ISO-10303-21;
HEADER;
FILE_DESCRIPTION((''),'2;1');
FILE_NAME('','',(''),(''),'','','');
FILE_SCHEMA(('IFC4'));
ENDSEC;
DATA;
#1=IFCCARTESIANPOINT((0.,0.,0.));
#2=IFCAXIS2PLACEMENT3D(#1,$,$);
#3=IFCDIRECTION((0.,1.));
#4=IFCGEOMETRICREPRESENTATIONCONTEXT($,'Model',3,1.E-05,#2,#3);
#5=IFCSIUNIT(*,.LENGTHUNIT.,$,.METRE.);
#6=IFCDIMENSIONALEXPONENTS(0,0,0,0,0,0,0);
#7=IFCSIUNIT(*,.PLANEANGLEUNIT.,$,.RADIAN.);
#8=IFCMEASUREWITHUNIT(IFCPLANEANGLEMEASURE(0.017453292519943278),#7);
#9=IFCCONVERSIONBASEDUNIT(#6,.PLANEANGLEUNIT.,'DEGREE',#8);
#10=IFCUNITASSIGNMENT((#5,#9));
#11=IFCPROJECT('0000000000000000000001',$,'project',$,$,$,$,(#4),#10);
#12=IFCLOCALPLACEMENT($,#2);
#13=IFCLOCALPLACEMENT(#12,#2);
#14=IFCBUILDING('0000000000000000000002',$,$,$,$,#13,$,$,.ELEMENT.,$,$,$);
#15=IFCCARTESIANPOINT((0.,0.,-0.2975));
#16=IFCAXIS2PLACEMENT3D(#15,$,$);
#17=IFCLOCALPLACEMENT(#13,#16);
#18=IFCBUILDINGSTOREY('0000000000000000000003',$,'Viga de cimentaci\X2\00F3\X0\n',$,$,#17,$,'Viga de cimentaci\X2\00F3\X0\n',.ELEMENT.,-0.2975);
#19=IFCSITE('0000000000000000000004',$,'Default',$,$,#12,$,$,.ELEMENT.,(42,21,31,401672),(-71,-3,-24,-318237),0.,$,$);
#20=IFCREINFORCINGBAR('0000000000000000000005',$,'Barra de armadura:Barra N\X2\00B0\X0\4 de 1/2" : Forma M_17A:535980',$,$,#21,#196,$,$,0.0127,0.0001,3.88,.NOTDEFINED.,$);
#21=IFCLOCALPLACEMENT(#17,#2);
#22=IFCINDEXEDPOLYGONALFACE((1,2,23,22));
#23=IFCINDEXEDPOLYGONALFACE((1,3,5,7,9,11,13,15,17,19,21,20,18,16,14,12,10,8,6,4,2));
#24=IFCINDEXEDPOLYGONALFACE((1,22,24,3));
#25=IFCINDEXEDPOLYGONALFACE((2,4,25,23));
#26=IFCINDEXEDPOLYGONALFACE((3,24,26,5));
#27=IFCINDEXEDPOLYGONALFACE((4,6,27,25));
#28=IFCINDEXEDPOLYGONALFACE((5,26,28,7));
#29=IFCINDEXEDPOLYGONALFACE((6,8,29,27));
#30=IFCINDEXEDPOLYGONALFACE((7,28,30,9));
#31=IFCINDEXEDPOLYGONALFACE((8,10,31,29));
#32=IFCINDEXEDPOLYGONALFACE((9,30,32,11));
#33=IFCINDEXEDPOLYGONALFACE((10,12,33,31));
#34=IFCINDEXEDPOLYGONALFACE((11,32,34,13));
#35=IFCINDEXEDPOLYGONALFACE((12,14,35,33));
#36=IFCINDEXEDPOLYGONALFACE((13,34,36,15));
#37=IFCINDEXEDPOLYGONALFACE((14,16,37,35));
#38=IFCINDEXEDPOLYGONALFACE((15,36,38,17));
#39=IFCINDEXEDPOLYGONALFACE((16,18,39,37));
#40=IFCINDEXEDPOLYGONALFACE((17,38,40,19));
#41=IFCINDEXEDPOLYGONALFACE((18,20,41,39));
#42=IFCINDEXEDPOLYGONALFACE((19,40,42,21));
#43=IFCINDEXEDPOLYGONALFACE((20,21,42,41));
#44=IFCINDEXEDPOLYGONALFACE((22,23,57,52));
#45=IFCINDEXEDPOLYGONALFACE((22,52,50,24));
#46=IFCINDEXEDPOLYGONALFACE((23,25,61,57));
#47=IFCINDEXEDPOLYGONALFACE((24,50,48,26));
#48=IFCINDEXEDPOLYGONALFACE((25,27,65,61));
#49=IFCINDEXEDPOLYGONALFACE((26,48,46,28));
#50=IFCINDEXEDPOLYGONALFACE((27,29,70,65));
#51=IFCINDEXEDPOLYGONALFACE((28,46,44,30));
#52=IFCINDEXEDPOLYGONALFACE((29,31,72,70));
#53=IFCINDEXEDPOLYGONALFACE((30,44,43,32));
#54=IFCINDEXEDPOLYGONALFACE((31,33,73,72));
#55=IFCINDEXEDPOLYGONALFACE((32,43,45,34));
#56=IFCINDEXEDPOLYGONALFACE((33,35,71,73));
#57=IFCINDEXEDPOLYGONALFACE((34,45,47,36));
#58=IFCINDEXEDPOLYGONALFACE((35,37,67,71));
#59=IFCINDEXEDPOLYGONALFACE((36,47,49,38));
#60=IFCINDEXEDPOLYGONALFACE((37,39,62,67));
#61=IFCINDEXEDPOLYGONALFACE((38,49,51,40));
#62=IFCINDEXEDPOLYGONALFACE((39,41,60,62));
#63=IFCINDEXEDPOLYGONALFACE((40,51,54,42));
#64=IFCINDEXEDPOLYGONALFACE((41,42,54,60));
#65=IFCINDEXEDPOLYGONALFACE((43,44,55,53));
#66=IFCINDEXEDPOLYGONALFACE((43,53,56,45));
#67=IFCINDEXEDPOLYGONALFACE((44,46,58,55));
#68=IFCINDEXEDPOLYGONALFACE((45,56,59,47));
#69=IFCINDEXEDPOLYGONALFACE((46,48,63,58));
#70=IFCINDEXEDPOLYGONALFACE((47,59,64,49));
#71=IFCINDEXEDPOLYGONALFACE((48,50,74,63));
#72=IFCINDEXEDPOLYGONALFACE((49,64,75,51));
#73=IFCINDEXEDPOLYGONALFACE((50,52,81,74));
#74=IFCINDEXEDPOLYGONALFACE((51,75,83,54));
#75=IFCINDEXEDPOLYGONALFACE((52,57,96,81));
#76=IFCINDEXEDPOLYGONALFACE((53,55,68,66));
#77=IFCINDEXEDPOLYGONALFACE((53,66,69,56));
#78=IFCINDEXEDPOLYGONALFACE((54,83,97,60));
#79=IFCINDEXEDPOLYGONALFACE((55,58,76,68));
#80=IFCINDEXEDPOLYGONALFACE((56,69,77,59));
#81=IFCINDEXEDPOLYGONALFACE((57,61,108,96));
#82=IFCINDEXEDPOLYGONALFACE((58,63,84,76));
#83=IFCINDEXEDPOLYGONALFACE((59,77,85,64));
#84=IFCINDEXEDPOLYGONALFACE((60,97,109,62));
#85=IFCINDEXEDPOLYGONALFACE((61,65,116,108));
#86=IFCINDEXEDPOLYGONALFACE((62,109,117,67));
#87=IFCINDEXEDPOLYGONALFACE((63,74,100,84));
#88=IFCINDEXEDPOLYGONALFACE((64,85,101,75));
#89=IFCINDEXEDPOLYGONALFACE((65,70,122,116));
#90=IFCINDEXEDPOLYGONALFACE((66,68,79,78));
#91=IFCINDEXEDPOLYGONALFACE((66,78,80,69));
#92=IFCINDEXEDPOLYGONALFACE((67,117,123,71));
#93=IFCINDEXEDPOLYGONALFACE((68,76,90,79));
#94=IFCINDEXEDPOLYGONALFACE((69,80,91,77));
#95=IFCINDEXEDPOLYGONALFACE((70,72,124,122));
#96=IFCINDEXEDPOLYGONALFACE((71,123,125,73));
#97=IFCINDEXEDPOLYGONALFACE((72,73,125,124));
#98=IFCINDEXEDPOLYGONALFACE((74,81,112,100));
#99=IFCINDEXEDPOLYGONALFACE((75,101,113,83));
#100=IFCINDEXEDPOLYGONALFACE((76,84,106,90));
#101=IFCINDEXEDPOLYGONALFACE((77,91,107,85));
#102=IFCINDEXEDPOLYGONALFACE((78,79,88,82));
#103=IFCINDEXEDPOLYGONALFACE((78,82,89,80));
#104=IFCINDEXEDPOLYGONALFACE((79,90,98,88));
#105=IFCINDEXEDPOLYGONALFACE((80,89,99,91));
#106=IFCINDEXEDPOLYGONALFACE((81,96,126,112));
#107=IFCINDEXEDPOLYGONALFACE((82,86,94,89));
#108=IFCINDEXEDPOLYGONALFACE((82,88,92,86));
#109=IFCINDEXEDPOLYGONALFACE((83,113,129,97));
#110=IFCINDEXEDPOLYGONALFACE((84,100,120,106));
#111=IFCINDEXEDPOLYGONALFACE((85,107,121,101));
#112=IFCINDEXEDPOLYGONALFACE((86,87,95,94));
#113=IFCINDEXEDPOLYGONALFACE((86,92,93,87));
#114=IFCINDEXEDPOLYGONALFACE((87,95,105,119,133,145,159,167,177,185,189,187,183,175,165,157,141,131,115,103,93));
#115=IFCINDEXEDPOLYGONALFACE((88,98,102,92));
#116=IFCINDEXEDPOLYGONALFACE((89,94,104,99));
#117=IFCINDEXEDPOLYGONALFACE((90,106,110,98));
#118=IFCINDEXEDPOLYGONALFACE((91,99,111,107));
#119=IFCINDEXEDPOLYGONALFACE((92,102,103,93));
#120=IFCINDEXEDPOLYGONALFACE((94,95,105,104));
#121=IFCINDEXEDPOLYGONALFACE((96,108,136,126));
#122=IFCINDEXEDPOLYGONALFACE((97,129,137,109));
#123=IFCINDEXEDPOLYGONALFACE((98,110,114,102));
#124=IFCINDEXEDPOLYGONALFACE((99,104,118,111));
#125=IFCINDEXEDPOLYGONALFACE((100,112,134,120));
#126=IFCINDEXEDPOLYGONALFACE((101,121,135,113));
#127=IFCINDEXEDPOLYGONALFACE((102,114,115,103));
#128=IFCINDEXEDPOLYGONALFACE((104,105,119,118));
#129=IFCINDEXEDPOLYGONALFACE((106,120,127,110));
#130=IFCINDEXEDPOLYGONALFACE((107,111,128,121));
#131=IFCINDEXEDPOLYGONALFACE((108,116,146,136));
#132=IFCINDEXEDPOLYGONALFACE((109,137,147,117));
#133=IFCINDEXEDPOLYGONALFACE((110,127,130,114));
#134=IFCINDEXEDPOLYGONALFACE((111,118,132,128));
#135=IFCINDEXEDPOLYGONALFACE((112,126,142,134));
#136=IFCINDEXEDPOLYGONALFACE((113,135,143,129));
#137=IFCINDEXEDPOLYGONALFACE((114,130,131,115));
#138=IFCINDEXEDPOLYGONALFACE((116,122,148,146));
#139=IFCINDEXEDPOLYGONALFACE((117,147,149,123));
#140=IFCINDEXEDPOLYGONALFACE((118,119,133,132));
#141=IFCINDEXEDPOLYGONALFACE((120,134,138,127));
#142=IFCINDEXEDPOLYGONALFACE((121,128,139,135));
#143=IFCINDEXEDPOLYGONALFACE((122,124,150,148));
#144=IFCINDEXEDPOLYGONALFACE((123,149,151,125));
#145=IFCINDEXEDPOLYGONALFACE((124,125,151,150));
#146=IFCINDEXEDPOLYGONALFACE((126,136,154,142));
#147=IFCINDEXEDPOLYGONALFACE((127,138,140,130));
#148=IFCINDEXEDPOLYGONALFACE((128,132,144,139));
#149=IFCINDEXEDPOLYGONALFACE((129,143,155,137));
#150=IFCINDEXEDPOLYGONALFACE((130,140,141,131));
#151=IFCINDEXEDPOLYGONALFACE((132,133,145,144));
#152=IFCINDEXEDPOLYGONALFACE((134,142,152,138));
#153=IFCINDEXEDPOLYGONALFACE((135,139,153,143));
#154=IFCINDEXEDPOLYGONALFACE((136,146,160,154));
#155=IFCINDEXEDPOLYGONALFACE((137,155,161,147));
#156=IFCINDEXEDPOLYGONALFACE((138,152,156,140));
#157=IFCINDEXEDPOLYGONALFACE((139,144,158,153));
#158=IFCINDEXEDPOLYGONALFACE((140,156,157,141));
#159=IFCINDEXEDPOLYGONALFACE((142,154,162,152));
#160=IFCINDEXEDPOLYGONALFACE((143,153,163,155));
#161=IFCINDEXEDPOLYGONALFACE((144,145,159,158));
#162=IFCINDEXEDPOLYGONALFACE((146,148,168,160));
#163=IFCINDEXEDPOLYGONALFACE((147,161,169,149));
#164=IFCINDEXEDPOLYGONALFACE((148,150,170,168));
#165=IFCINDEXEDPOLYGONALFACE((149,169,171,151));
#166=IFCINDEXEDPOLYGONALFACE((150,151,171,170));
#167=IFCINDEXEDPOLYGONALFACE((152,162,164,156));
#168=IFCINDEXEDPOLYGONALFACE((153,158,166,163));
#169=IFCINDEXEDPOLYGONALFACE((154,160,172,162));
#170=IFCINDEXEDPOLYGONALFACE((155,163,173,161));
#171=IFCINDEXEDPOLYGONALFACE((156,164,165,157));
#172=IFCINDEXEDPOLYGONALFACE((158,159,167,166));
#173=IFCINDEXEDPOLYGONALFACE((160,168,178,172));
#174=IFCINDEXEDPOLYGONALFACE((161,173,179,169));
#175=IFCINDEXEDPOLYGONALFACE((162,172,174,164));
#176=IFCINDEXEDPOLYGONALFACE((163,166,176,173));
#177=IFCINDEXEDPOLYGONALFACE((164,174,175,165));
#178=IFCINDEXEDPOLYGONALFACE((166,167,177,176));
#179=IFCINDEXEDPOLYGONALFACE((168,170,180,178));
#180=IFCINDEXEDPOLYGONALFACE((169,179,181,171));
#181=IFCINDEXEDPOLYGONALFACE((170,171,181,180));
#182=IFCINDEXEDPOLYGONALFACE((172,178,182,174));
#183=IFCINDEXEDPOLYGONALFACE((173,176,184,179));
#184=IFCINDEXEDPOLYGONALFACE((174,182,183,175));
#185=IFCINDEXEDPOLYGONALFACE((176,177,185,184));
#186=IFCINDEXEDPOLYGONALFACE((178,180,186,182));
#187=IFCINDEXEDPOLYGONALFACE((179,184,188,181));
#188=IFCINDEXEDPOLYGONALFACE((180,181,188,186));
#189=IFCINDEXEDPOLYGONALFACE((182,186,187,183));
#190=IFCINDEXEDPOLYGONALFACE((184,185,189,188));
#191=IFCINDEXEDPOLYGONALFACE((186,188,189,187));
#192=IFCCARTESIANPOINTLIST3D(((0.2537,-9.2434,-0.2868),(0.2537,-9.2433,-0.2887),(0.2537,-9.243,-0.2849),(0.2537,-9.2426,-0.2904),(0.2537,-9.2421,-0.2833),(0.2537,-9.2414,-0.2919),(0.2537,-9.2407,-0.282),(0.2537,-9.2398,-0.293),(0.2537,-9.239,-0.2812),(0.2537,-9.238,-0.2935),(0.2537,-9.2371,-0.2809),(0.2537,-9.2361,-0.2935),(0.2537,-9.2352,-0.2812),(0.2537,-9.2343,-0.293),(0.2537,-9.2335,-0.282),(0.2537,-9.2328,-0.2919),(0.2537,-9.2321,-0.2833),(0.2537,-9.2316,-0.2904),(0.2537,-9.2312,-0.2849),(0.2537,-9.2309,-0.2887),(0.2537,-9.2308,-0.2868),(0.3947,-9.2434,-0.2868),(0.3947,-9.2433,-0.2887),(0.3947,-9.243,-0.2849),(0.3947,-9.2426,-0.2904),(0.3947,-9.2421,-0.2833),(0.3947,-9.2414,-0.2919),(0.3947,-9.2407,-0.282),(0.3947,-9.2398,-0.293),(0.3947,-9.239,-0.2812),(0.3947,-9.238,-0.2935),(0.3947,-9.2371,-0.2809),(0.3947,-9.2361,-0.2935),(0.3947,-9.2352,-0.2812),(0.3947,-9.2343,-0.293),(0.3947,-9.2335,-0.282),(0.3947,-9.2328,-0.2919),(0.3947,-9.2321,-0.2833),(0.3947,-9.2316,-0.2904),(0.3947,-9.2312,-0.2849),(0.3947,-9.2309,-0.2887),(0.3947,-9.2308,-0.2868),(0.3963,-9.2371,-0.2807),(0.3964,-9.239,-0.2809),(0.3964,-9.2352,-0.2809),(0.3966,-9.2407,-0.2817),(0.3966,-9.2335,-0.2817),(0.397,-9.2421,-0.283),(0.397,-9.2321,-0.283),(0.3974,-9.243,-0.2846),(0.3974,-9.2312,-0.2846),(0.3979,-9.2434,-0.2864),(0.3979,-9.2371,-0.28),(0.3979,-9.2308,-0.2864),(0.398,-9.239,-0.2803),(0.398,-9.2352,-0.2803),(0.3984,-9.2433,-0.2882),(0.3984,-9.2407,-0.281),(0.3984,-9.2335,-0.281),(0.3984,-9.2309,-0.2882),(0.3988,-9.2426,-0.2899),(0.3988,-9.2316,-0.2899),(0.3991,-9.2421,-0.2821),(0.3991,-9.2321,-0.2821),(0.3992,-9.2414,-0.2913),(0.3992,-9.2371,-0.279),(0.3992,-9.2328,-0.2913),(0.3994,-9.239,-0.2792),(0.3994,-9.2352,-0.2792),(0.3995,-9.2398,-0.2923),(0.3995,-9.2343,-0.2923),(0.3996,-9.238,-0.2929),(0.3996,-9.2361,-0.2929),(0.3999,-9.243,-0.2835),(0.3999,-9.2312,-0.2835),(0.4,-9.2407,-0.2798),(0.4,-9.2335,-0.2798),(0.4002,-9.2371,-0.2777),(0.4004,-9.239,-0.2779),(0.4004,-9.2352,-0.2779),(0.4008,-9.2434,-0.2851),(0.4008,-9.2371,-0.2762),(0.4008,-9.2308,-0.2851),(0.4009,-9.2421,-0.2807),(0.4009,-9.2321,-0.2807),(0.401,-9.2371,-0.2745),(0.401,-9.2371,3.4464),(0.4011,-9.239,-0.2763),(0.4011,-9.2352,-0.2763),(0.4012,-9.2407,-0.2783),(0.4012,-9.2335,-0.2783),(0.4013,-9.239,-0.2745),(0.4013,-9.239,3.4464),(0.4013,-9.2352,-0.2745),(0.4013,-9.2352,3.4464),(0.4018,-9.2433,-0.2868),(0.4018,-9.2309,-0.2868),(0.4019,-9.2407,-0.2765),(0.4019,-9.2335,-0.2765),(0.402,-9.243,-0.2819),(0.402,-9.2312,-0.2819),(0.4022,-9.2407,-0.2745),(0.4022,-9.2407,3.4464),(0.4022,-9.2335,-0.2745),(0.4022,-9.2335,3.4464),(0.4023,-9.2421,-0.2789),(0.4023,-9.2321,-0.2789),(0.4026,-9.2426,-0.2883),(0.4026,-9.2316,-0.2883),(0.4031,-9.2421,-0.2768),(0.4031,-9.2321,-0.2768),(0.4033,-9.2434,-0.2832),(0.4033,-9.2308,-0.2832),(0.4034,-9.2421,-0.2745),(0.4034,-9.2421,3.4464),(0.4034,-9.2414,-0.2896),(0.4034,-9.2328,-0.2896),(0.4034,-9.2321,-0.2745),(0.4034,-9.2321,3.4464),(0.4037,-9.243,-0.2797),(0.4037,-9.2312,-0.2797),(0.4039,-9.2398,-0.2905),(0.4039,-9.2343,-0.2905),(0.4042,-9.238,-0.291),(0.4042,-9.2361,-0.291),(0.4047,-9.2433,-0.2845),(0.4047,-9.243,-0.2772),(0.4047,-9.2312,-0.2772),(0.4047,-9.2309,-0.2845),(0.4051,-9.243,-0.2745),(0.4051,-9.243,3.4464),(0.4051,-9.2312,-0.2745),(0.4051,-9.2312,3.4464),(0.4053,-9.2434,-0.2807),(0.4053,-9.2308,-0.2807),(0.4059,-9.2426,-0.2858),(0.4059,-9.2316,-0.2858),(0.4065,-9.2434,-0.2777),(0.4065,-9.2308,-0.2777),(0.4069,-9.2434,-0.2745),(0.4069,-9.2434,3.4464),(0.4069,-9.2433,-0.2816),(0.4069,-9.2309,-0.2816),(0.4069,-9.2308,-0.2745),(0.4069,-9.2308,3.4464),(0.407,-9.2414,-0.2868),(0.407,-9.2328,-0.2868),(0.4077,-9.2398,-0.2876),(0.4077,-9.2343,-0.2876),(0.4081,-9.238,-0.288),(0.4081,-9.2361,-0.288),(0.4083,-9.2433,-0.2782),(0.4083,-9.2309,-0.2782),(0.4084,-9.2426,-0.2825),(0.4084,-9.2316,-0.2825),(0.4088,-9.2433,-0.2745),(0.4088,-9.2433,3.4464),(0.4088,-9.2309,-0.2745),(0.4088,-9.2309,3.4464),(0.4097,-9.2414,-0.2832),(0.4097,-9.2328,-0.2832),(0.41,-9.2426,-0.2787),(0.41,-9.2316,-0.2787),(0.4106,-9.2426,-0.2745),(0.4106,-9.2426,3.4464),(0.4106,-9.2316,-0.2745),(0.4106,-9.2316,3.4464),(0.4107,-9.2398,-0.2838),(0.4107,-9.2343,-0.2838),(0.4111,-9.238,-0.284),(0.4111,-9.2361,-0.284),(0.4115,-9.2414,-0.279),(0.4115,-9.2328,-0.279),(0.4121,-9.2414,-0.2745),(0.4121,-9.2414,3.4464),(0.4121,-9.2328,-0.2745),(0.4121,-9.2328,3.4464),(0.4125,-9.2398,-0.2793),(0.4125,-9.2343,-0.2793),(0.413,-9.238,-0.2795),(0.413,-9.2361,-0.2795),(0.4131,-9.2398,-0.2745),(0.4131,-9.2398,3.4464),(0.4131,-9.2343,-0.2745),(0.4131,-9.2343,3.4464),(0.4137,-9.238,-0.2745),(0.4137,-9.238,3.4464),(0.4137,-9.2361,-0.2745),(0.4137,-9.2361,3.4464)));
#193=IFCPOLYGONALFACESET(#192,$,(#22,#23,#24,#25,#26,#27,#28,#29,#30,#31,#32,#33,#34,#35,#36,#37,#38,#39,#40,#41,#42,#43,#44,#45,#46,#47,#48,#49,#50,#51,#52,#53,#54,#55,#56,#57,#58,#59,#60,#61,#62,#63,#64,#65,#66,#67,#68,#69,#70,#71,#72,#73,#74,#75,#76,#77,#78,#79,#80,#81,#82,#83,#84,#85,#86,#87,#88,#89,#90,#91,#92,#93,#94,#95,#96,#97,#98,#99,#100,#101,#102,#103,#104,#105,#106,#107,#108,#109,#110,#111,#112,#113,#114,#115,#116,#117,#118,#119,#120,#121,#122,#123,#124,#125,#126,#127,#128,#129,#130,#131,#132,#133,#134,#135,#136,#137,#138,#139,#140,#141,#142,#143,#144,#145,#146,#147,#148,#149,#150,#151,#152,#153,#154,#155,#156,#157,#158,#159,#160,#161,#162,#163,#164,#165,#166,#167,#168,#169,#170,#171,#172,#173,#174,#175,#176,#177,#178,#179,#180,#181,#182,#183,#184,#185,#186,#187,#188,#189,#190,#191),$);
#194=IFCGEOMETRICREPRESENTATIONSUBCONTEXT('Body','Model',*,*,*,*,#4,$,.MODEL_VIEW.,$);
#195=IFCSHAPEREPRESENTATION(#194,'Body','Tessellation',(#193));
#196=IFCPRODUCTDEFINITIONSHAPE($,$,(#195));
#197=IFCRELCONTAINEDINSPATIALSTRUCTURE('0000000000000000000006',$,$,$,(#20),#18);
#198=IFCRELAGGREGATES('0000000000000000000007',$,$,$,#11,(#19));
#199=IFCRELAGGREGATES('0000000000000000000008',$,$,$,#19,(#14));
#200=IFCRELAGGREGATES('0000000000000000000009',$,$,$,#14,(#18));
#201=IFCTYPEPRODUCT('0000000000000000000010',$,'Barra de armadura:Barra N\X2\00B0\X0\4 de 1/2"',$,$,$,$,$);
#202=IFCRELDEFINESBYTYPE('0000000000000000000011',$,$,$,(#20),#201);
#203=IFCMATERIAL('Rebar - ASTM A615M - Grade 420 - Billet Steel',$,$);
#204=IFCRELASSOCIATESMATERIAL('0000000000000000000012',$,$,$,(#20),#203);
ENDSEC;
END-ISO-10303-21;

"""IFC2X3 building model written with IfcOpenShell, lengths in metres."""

from ifc_helpers import new_model, entity, si_unit, converted_unit, direction, frame, origin, place, context, subcontext, project, spatial, material, type_object, element, save


model = new_model("IFC2X3")

# Units and contexts
model_context = context("Model", 3, precision=1e-05, world=origin(), true_north=direction((0.0, 1.0)))
body_context = subcontext(model_context, "Body", "Model", "MODEL_VIEW")
ifc_project = project(units=[si_unit("LENGTHUNIT", "METRE"), converted_unit("PLANEANGLEUNIT", "DEGREE", entity("IfcPlaneAngleMeasure", 0.017453292519943278), si_unit("PLANEANGLEUNIT", "RADIAN"), dimensions=[0, 0, 0, 0, 0, 0, 0])], contexts=[model_context])

# Site, building, storey
site_placement = place(None, origin())
site = spatial("IfcSite", under=ifc_project, at=site_placement, Name="Default", CompositionType="ELEMENT", RefLatitude=(42, 21, 31, 401672), RefLongitude=(-71, -3, -24, -318237), RefElevation=0.0)
building_placement = place(site_placement, origin())
building = spatial("IfcBuilding", under=site, at=building_placement, CompositionType="ELEMENT")
storey_placement = place(building_placement, frame((0.0, 0.0, -0.2975)))
storey = spatial("IfcBuildingStorey", under=building, at=storey_placement, Name="Viga de cimentación", LongName="Viga de cimentación", CompositionType="ELEMENT", Elevation=-0.2975)

# Reinforcing bar
ifc_material = material(Name="Rebar - ASTM A615M - Grade 420 - Billet Steel")
type_product_1 = type_object("IfcTypeProduct", Name="Barra de armadura:Barra N°4 de 1/2\"")
reinforcing_bar_1_placement = place(storey_placement, origin())
element("IfcReinforcingBar", 1, at=reinforcing_bar_1_placement, inside=storey, type_object=type_product_1, material=ifc_material, Name="Barra de armadura:Barra N°4 de 1/2\" : Forma M_17A:535980", BarLength=3.88, BarRole="NOTDEFINED", CrossSectionArea=0.0001, NominalDiameter=0.0127, context=body_context, shape_type="AdvancedSweptSolid", body=[
    entity("IfcSweptDiskSolid", entity("IfcCompositeCurve", [entity("IfcCompositeCurveSegment", "CONTINUOUS", True, entity("IfcPolyline", [entity("IfcCartesianPoint", [0.4074, -9.2371, 3.4464]), entity("IfcCartesianPoint", [0.4074, -9.2371, -0.2745])])), entity("IfcCompositeCurveSegment", "CONTINUOUS", True, entity("IfcTrimmedCurve", entity("IfcCircle", entity("IfcAxis2Placement3D", entity("IfcCartesianPoint", [0.3947, -9.2371, -0.2745]), entity("IfcDirection", [0.0, 1.0, 0.0]), entity("IfcDirection", [0.0, 0.0, -1.0])), 0.0127), [entity("IfcParameterValue", 270.0)], [entity("IfcParameterValue", 360.0)], True, "PARAMETER")), entity("IfcCompositeCurveSegment", "CONTINUOUS", True, entity("IfcPolyline", [entity("IfcCartesianPoint", [0.3947, -9.2371, -0.2872]), entity("IfcCartesianPoint", [0.2537, -9.2371, -0.2872])]))], False), 0.0063, None, 0.0, 92.0),
])

save(model, "model.ifc")
